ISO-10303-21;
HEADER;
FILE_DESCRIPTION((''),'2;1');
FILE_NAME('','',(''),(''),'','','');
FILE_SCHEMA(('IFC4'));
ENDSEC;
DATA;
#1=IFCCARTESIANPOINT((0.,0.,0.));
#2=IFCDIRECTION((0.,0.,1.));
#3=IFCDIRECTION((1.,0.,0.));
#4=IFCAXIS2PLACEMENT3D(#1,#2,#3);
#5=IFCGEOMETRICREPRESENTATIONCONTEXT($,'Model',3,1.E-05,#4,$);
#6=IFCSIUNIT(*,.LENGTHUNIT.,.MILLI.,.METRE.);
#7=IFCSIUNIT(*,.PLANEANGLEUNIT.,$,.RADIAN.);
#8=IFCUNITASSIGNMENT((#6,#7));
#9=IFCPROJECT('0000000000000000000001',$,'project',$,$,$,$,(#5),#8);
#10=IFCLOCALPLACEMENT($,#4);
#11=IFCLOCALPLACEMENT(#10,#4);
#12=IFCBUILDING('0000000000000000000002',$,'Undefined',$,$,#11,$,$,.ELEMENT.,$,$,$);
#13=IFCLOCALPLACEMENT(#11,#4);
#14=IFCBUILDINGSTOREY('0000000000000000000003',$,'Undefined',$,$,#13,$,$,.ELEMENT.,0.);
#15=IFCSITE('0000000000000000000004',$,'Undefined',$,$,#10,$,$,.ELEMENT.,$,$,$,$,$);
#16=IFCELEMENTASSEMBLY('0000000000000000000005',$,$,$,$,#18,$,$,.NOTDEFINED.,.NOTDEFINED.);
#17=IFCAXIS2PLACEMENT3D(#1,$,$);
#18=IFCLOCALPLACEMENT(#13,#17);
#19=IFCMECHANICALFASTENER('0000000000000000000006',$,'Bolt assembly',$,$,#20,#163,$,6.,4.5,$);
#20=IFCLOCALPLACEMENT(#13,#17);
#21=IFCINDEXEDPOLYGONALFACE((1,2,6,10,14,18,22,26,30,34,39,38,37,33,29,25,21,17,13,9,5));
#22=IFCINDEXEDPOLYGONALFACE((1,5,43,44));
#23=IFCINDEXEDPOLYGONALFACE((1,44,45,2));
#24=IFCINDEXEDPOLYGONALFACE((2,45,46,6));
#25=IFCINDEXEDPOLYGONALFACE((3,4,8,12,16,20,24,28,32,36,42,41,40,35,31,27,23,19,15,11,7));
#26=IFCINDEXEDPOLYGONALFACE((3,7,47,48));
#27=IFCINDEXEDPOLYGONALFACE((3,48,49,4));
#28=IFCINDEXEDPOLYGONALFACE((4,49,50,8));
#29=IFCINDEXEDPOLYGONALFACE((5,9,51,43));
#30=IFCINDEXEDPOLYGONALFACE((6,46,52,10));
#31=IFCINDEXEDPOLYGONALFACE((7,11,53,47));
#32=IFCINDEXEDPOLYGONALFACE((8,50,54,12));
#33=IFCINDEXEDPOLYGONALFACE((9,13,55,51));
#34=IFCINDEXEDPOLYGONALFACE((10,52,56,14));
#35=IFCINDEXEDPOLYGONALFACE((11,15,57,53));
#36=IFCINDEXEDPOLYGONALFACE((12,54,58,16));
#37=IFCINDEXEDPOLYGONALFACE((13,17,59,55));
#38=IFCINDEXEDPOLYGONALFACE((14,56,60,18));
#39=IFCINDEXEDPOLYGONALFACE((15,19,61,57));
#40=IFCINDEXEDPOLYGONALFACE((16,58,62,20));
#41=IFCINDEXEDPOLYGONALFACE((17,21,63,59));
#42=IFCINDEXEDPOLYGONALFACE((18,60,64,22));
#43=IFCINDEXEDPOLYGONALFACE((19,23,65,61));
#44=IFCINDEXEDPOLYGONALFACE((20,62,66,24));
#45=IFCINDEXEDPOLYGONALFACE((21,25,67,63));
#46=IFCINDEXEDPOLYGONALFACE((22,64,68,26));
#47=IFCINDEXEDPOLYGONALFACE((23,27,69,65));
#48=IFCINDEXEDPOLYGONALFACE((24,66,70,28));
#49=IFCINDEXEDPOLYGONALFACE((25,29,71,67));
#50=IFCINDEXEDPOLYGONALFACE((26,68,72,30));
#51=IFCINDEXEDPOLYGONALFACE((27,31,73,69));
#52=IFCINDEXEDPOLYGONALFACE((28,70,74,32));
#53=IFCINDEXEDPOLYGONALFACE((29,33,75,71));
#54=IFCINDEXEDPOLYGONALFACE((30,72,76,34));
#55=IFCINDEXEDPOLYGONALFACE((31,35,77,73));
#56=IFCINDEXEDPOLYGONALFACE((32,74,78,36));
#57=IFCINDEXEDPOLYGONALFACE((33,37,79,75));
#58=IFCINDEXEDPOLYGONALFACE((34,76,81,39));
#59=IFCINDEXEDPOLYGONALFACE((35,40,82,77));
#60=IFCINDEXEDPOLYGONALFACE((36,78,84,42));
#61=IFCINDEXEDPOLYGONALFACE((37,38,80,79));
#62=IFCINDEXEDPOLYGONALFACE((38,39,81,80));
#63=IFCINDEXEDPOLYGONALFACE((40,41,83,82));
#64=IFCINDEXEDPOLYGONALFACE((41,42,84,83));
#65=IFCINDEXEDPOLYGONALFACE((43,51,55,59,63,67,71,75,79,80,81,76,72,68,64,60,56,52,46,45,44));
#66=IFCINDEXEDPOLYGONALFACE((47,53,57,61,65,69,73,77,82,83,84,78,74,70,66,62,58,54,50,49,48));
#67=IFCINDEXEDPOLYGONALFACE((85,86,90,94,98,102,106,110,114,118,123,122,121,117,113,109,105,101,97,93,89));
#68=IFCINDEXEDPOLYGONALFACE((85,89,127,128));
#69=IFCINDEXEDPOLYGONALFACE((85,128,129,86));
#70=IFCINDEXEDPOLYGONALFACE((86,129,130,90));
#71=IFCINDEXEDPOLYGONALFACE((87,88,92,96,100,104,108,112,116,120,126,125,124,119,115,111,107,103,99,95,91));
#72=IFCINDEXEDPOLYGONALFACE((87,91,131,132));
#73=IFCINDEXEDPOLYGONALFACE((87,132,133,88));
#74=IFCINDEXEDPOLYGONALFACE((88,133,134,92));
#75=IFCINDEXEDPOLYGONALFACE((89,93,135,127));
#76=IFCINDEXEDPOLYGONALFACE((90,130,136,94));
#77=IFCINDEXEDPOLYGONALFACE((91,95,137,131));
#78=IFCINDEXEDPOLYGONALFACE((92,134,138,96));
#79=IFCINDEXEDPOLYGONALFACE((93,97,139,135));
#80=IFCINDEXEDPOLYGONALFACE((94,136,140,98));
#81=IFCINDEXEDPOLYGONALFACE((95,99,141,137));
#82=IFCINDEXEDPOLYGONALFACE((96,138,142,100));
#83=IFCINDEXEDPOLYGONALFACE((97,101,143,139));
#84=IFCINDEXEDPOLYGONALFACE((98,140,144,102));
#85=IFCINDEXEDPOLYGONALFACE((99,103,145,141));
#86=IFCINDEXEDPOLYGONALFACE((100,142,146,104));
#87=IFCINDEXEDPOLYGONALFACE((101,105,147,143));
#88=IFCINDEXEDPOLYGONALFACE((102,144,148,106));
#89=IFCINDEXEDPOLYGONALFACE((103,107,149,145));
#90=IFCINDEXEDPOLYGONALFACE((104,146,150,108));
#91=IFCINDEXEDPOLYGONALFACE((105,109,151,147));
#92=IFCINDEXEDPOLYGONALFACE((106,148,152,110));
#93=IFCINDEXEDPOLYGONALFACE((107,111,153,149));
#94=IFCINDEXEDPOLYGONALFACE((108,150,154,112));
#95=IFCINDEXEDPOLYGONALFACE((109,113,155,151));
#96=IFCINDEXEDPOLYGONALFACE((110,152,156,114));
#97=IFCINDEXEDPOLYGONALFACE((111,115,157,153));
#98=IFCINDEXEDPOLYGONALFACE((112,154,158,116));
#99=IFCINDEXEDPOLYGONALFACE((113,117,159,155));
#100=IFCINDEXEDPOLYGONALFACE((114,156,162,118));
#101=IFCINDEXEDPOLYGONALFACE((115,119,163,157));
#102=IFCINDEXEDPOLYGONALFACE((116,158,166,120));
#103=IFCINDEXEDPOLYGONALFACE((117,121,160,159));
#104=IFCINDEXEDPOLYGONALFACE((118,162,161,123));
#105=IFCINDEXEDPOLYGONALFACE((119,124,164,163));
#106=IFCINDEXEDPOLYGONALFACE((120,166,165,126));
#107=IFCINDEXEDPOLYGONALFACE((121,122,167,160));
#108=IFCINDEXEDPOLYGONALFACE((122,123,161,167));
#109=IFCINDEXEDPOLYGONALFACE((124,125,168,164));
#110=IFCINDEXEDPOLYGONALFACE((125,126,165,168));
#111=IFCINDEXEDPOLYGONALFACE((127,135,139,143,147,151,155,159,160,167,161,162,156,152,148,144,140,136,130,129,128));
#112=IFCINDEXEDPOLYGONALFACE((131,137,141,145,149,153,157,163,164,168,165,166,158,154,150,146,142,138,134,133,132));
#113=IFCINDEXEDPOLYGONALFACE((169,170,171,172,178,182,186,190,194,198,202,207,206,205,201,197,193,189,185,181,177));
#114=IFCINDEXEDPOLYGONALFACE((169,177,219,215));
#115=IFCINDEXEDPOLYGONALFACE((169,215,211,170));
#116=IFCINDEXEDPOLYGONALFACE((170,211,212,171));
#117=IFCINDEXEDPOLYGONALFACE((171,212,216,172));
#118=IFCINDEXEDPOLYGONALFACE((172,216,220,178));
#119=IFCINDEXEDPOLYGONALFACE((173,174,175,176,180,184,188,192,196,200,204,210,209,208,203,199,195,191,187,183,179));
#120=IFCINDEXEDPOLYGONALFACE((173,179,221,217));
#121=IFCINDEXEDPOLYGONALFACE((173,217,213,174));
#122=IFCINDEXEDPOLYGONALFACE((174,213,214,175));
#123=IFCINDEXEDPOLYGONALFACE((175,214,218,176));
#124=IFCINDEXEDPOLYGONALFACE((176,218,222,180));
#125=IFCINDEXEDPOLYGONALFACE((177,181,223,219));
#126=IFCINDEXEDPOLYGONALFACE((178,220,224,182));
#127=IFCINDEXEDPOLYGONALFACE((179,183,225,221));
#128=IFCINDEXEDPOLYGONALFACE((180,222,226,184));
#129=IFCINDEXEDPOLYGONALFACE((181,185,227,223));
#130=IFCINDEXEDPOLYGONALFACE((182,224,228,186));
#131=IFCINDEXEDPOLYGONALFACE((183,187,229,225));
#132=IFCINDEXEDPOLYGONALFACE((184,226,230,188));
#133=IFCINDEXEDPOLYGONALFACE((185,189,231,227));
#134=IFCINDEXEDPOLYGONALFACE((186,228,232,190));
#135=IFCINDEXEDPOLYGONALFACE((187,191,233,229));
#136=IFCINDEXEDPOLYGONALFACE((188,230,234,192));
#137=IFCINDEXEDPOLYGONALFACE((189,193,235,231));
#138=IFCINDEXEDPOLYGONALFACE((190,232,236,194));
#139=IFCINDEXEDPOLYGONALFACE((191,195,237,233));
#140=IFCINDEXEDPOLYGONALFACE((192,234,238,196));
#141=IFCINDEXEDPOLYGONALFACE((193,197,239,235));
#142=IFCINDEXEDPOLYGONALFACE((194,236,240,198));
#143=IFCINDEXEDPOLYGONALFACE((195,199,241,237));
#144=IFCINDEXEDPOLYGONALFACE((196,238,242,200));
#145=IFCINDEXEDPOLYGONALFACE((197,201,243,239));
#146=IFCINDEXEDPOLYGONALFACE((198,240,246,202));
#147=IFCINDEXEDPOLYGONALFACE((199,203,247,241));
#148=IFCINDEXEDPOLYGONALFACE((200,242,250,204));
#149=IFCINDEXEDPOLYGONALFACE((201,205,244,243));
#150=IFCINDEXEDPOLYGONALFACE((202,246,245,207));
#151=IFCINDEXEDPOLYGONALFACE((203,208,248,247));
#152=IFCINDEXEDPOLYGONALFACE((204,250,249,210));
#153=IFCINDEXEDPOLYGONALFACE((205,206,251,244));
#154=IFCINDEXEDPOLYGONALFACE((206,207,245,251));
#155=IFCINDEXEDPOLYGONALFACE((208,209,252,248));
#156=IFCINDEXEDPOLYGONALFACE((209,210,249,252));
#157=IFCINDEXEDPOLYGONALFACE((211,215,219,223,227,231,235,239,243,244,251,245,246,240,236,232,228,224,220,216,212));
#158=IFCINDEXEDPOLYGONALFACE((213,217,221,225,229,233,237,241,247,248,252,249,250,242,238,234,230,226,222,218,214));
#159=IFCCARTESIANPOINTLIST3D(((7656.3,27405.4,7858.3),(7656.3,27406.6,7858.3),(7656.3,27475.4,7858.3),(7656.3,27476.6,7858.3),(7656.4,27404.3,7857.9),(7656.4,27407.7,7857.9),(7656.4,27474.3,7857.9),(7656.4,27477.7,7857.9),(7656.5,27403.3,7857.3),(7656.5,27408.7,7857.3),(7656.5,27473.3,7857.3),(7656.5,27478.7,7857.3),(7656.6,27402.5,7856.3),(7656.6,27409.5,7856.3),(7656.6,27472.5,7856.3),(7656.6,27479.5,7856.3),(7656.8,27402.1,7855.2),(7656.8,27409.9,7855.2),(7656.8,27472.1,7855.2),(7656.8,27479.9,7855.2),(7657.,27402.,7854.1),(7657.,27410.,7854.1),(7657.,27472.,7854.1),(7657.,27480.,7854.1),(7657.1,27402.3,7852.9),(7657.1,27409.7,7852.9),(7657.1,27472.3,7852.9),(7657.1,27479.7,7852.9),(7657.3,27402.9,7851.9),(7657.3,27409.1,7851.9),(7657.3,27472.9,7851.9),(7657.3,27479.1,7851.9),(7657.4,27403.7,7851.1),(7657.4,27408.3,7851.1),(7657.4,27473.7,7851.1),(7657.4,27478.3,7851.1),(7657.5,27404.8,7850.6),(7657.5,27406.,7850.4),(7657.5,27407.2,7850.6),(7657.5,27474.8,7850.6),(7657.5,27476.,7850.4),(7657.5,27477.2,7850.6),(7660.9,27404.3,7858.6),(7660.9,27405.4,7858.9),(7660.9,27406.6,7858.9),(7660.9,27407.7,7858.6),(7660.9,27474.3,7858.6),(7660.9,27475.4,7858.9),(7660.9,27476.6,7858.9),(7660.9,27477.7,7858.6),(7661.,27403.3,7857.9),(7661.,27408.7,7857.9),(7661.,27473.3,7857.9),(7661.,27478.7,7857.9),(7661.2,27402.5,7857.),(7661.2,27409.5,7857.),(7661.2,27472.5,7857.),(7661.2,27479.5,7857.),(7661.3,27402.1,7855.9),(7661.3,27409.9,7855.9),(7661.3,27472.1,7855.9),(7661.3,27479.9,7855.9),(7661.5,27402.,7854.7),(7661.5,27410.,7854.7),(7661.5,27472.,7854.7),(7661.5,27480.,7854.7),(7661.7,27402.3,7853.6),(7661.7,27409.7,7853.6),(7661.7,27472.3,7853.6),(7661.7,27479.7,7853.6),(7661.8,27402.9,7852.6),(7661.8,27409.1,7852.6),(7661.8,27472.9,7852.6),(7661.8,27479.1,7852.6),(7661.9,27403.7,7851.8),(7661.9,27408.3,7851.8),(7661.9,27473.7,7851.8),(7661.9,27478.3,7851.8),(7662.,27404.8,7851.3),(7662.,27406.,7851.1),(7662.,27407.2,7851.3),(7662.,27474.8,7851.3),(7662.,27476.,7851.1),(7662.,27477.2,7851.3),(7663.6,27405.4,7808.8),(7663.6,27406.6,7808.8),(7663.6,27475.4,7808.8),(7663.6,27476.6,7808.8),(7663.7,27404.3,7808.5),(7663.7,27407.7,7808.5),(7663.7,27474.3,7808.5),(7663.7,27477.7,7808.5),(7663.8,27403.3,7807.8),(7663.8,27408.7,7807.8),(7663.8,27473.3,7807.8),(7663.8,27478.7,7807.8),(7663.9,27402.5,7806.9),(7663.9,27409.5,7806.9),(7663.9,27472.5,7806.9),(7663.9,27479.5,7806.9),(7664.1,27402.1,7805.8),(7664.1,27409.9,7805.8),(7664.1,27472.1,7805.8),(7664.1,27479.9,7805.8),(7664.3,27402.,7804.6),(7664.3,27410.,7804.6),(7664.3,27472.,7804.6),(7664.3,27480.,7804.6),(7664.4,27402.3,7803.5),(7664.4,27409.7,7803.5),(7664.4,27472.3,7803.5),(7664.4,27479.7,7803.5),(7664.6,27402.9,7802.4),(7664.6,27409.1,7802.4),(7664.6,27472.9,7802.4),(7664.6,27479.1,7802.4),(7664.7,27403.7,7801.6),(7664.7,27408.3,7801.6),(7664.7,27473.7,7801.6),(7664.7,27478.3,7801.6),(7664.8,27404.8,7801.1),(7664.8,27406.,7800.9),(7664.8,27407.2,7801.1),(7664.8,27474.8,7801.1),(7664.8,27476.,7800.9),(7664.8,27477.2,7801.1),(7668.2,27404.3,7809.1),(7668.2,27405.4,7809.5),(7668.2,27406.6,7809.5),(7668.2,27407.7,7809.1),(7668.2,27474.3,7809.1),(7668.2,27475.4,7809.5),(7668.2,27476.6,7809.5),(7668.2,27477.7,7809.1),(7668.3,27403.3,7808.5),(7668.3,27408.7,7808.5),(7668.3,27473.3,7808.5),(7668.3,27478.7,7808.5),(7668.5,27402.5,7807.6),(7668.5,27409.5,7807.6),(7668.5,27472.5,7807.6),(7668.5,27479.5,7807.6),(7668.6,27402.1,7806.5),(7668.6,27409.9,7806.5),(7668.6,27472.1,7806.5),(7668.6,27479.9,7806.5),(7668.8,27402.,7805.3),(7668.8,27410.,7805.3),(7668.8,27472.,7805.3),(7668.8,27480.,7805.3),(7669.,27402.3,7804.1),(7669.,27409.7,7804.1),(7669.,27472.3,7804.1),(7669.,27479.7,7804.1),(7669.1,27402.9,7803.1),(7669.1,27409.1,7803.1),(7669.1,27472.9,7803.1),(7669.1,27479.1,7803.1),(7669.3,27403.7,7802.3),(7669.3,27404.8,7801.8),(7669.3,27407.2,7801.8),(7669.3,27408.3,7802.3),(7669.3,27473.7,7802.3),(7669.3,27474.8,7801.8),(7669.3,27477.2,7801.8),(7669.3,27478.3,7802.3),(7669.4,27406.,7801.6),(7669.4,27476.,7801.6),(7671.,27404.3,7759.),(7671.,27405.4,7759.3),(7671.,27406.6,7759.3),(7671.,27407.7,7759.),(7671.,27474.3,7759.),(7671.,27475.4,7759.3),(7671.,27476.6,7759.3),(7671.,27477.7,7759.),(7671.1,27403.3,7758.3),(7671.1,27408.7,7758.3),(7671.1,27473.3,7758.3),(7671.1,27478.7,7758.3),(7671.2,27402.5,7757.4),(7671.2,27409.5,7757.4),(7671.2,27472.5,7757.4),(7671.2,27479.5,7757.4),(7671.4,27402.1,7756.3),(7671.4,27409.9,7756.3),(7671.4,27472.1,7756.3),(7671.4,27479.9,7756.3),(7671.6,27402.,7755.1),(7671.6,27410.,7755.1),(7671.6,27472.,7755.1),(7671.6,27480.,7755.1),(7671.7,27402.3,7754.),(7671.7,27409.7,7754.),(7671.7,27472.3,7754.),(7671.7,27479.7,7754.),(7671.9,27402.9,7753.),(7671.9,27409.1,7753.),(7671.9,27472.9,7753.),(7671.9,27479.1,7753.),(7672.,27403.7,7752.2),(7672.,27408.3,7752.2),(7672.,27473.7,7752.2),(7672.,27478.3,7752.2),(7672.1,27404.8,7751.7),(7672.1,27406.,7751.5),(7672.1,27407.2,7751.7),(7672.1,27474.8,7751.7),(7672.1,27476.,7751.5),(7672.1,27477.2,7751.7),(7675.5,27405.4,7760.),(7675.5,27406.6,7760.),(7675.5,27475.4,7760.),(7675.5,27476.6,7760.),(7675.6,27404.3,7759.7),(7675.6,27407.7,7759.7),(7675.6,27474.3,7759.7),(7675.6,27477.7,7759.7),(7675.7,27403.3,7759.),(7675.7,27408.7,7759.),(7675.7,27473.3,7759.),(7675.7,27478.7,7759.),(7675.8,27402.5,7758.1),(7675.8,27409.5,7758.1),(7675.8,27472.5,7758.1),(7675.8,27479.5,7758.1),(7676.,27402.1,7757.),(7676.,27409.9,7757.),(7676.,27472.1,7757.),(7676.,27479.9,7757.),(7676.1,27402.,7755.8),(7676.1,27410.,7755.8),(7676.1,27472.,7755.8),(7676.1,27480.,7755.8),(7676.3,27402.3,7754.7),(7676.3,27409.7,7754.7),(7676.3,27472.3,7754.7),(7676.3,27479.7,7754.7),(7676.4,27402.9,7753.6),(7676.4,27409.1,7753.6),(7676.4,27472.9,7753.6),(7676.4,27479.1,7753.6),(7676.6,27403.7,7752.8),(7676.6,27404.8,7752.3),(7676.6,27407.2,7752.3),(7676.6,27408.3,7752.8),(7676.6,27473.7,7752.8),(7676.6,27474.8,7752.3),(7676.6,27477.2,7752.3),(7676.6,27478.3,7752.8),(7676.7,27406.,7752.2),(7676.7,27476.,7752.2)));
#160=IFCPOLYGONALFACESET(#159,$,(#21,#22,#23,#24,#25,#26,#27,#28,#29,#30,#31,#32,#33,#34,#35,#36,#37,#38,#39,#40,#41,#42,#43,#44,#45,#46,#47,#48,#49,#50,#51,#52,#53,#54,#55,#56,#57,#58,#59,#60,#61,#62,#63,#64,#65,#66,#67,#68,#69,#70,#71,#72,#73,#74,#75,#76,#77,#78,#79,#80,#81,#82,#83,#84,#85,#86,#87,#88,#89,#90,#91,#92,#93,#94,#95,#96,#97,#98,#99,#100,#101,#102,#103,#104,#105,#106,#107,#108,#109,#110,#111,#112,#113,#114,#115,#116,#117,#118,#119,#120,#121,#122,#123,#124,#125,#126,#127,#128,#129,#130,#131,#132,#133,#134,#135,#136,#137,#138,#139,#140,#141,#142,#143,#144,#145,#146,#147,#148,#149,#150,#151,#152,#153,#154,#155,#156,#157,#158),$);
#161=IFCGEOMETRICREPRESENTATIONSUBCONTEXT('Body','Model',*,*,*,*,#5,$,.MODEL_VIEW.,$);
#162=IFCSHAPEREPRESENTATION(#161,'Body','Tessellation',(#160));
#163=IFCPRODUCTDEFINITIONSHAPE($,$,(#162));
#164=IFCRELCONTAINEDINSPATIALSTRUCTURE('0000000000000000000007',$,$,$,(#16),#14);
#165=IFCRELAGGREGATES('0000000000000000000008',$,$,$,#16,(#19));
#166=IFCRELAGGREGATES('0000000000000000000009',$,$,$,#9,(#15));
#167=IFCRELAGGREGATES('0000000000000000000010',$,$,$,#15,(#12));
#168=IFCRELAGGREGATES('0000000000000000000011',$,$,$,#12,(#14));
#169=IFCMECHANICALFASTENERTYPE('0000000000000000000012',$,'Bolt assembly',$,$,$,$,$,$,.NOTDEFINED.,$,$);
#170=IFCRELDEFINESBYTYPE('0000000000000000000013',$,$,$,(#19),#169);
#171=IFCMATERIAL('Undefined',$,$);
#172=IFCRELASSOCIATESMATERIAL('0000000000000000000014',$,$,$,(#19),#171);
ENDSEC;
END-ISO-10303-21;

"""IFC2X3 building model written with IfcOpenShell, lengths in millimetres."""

from ifc_helpers import new_model, si_unit, frame, origin_with_axes, origin_2d_with_axis, place, context, subcontext, project, spatial, circle, extrude, source, transform, mapped, material, type_object, element, aggregate, save


model = new_model("IFC2X3")

# Units and contexts
model_context = context("Model", 3, precision=1e-05, world=origin_with_axes())
body_context = subcontext(model_context, "Body", "Model", "MODEL_VIEW")
ifc_project = project(units=[si_unit("LENGTHUNIT", "METRE", prefix="MILLI"), si_unit("PLANEANGLEUNIT", "RADIAN")], contexts=[model_context])

# Site, building, storey
site_placement = place(None, origin_with_axes())
site = spatial("IfcSite", under=ifc_project, at=site_placement, Name="Undefined", CompositionType="ELEMENT")
building_placement = place(site_placement, origin_with_axes())
building = spatial("IfcBuilding", under=site, at=building_placement, Name="Undefined", CompositionType="ELEMENT")
storey_placement = place(building_placement, origin_with_axes())
storey = spatial("IfcBuildingStorey", under=building, at=storey_placement, Name="Undefined", CompositionType="ELEMENT", Elevation=0.0)

# Element assembly
assembly_1_placement = place(storey_placement, origin_with_axes())
assembly_1 = element("IfcElementAssembly", 1, at=assembly_1_placement, inside=storey, AssemblyPlace="NOTDEFINED", PredefinedType="NOTDEFINED")

# Mechanical fastener
ifc_material_1 = material(Name="Undefined")
mechanical_fastener_type = type_object("IfcMechanicalFastenerType", Name="Bolt assembly")
shared_shape_1 = source(origin_with_axes(), body_context, "Body", "SweptSolid", [
    extrude(circle(Radius=4.0, at=origin_2d_with_axis()), frame((0.0, 0.0, 0.0), z_axis=(0.0, 1.0, 0.0), x_axis=(1.0, 0.0, 0.0)), (0.0, 0.0, 1.0), 4.6),
])
mechanical_fastener_1_placement = place(assembly_1_placement, frame((7656.9, 27441.0, 7854.4), z_axis=(0.0, -1.0, 0.0), x_axis=(0.146203, 0.0, -0.989255)))
mechanical_fastener_1 = element("IfcMechanicalFastener", 2, at=mechanical_fastener_1_placement, type_object=mechanical_fastener_type, material=ifc_material_1, Name="Bolt assembly", NominalDiameter=6.0, NominalLength=4.5, context=body_context, shape_type="MappedRepresentation", body=[
    mapped(shared_shape_1, transform((0.0, 0.0, -35.0))),
    mapped(shared_shape_1, transform((50.0, 0.0, -35.0))),
    mapped(shared_shape_1, transform((100.0, 0.0, -35.0))),
    mapped(shared_shape_1, transform((0.0, 0.0, 35.0))),
    mapped(shared_shape_1, transform((50.0, 0.0, 35.0))),
    mapped(shared_shape_1, transform((100.0, 0.0, 35.0))),
])

aggregate(assembly_1, [mechanical_fastener_1])

save(model, "model.ifc")
